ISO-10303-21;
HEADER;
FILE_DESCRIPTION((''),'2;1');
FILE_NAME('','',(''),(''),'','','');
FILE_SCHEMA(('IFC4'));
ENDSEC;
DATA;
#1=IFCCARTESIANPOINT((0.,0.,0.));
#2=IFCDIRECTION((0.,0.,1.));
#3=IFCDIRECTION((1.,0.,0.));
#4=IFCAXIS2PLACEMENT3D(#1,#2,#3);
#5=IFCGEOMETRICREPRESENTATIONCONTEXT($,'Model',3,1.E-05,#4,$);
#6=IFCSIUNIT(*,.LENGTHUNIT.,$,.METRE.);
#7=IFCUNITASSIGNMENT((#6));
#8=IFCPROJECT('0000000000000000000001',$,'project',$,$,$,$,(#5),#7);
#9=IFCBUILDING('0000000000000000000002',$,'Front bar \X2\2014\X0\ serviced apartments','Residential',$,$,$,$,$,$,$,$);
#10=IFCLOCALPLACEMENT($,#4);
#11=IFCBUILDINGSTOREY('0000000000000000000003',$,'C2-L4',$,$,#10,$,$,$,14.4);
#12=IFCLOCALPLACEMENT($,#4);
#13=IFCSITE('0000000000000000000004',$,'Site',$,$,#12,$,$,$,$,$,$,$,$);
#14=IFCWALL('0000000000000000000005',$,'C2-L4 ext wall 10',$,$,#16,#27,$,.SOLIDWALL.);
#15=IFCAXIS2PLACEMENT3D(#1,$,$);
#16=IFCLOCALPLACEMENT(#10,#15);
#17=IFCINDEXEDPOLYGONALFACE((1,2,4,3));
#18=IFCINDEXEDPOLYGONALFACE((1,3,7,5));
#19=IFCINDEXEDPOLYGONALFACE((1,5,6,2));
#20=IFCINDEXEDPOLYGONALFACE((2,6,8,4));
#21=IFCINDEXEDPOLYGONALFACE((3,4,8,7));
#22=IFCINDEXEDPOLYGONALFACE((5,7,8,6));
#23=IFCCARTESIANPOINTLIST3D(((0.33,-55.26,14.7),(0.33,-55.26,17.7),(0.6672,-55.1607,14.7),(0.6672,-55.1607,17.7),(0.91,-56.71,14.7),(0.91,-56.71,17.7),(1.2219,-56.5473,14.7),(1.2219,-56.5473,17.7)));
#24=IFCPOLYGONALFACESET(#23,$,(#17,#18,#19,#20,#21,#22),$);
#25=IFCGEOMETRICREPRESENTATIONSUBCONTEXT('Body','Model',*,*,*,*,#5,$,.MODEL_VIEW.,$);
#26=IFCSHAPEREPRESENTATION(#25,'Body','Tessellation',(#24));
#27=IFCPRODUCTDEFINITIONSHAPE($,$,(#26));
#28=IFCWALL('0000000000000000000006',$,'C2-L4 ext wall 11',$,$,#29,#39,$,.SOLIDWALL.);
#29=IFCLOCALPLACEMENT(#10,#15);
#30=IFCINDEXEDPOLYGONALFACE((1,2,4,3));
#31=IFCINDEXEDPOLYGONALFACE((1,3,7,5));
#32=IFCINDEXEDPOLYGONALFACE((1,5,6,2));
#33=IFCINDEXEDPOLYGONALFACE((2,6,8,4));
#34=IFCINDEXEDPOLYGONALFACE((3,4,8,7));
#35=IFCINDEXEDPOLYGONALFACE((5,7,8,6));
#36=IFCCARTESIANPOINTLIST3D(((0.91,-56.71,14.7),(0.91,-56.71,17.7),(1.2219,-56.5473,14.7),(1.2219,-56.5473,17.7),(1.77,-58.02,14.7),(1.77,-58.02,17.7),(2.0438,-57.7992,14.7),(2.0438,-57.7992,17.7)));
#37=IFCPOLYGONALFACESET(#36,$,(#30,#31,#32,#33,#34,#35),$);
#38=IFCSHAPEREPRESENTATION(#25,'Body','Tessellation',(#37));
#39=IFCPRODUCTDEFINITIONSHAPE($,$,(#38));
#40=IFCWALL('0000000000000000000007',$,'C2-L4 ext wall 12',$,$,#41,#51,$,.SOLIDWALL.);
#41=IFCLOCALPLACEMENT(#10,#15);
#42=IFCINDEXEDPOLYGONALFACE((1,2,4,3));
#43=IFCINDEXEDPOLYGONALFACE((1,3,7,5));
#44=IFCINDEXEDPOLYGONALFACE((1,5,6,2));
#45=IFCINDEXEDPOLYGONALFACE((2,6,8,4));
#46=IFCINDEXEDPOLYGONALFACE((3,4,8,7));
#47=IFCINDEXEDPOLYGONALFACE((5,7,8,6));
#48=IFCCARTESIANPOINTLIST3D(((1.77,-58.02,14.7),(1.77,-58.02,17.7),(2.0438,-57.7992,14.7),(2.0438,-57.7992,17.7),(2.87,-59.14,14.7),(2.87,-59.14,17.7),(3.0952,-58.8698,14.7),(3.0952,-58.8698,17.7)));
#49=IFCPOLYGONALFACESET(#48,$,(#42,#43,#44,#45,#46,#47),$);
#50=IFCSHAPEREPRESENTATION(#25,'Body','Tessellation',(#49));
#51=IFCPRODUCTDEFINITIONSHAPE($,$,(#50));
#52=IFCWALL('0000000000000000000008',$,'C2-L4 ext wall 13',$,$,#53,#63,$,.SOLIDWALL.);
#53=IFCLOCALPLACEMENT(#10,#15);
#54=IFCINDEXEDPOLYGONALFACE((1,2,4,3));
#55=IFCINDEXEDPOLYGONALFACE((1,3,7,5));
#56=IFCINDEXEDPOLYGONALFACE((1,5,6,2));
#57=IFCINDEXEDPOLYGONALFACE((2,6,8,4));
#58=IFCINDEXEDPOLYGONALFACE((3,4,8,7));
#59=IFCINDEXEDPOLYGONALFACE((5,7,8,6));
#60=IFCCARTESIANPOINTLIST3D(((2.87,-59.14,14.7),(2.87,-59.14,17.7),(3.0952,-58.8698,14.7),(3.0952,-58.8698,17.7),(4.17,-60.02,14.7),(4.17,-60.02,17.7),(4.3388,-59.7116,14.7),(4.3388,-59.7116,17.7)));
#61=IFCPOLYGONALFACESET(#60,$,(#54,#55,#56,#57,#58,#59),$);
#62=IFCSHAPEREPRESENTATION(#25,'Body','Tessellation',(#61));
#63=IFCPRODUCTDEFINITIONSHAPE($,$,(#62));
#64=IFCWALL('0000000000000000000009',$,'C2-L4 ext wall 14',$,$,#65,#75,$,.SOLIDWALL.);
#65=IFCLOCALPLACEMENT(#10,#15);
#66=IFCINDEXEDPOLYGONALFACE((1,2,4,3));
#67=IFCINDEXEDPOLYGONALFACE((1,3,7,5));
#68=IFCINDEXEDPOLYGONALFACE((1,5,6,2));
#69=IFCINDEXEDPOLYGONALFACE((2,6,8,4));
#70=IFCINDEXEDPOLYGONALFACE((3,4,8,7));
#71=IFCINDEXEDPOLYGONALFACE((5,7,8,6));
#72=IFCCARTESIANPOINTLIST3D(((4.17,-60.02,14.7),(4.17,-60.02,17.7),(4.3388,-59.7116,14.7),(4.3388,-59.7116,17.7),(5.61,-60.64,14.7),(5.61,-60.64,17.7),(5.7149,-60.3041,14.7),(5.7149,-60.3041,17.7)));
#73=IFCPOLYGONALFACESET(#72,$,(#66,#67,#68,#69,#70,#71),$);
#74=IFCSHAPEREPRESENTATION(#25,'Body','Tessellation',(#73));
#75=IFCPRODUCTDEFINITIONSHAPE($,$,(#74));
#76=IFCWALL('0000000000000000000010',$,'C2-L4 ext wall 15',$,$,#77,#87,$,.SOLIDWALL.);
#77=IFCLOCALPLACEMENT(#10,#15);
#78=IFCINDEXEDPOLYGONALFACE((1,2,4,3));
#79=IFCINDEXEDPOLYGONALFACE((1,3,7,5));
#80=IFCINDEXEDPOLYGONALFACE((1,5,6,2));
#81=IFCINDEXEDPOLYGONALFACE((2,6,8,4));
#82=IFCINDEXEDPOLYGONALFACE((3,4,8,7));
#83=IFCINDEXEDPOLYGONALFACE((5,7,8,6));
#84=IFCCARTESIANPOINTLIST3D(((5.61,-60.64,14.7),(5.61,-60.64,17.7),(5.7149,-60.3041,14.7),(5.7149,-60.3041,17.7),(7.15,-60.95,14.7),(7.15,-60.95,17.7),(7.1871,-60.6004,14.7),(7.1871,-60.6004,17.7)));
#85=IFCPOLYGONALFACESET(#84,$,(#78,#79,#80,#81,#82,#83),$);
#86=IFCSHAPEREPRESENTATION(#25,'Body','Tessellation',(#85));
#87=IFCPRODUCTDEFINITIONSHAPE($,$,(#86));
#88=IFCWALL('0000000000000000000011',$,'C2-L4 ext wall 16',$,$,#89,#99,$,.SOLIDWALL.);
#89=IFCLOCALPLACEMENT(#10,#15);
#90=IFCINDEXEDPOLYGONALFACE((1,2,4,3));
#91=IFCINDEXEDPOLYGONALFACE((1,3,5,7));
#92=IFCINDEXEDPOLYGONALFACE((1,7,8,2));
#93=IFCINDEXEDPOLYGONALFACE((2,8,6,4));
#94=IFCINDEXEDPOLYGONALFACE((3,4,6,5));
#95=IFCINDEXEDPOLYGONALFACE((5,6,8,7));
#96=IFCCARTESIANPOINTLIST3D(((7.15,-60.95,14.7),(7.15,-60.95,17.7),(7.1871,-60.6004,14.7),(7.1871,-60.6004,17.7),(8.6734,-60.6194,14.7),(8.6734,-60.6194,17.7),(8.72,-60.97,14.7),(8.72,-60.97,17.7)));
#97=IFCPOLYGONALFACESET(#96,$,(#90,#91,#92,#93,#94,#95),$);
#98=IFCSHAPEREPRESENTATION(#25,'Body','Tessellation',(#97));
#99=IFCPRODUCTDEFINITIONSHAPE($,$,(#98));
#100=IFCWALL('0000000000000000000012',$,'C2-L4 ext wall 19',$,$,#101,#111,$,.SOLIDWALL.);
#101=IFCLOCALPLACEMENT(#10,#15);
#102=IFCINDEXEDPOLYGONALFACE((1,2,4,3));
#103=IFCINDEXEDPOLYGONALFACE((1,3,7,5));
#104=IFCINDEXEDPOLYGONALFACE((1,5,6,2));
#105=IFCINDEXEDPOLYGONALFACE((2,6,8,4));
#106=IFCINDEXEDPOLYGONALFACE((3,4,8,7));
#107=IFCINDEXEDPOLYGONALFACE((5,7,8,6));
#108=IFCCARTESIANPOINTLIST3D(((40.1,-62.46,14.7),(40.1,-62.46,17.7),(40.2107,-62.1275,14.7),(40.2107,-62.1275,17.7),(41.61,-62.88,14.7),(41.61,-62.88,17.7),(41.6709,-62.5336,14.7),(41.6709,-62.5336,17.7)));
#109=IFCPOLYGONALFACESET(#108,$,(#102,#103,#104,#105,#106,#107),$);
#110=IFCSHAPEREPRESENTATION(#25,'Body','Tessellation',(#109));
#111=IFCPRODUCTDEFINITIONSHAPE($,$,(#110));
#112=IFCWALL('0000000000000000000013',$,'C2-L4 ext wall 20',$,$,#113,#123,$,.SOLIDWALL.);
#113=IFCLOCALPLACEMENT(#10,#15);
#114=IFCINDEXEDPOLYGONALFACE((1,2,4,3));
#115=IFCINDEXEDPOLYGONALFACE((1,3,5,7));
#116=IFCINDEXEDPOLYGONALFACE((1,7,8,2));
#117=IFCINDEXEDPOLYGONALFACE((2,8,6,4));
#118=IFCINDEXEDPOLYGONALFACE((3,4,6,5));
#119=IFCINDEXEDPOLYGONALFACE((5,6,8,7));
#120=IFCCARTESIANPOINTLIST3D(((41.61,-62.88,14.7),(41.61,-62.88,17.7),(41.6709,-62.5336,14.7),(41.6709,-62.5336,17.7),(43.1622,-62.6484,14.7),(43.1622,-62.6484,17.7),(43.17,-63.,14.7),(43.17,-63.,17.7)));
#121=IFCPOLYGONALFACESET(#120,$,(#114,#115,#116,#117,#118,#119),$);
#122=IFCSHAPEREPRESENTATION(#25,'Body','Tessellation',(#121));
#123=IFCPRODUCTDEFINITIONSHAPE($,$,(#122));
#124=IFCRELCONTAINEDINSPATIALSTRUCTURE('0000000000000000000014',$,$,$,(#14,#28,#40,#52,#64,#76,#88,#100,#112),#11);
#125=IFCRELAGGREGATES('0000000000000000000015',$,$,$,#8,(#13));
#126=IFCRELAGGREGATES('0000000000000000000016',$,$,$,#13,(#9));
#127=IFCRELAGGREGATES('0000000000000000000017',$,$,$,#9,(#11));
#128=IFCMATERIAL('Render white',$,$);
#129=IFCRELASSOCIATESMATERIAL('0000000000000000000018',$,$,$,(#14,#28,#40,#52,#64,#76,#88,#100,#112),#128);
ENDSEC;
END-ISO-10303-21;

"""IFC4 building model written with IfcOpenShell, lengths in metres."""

from ifc_helpers import new_model, si_unit, frame, origin_with_axes, place, context, subcontext, project, spatial, polyline, outline, extrude, material, element, save


model = new_model("IFC4")

# Units and contexts
model_context = context("Model", 3, precision=1e-05, world=origin_with_axes())
body_context = subcontext(model_context, "Body", "Model", "MODEL_VIEW")
ifc_project = project(units=[si_unit("LENGTHUNIT", "METRE")], contexts=[model_context])

# Site, building, storey
site_placement = place(None, origin_with_axes())
site = spatial("IfcSite", under=ifc_project, at=site_placement, Name="Site")
building = spatial("IfcBuilding", under=site, Name="Front bar — serviced apartments", Description="Residential")
storey_placement = place(None, origin_with_axes())
storey = spatial("IfcBuildingStorey", under=building, at=storey_placement, Name="C2-L4", Elevation=14.4)

# Walls
ifc_material_1 = material(Name="Render white")
wall_1_placement = place(storey_placement, origin_with_axes())
element("IfcWall", 1, at=wall_1_placement, inside=storey, material=ifc_material_1, Name="C2-L4 ext wall 10", PredefinedType="SOLIDWALL", context=body_context, shape_type="SweptSolid", body=[
    extrude(outline(polyline([(0.33, -55.26), (0.91, -56.71), (1.2219, -56.5473), (0.6672, -55.1607), (0.33, -55.26)])), frame((0.0, 0.0, 14.7), z_axis=(0.0, 0.0, 1.0), x_axis=(1.0, 0.0, 0.0)), (0.0, 0.0, 1.0), 3.0),
])
wall_2_placement = place(storey_placement, origin_with_axes())
element("IfcWall", 2, at=wall_2_placement, inside=storey, material=ifc_material_1, Name="C2-L4 ext wall 11", PredefinedType="SOLIDWALL", context=body_context, shape_type="SweptSolid", body=[
    extrude(outline(polyline([(0.91, -56.71), (1.77, -58.02), (2.0438, -57.7992), (1.2219, -56.5473), (0.91, -56.71)])), frame((0.0, 0.0, 14.7), z_axis=(0.0, 0.0, 1.0), x_axis=(1.0, 0.0, 0.0)), (0.0, 0.0, 1.0), 3.0),
])
wall_3_placement = place(storey_placement, origin_with_axes())
element("IfcWall", 3, at=wall_3_placement, inside=storey, material=ifc_material_1, Name="C2-L4 ext wall 12", PredefinedType="SOLIDWALL", context=body_context, shape_type="SweptSolid", body=[
    extrude(outline(polyline([(1.77, -58.02), (2.87, -59.14), (3.0952, -58.8698), (2.0438, -57.7992), (1.77, -58.02)])), frame((0.0, 0.0, 14.7), z_axis=(0.0, 0.0, 1.0), x_axis=(1.0, 0.0, 0.0)), (0.0, 0.0, 1.0), 3.0),
])
wall_4_placement = place(storey_placement, origin_with_axes())
element("IfcWall", 4, at=wall_4_placement, inside=storey, material=ifc_material_1, Name="C2-L4 ext wall 13", PredefinedType="SOLIDWALL", context=body_context, shape_type="SweptSolid", body=[
    extrude(outline(polyline([(2.87, -59.14), (4.17, -60.02), (4.3388, -59.7116), (3.0952, -58.8698), (2.87, -59.14)])), frame((0.0, 0.0, 14.7), z_axis=(0.0, 0.0, 1.0), x_axis=(1.0, 0.0, 0.0)), (0.0, 0.0, 1.0), 3.0),
])
wall_5_placement = place(storey_placement, origin_with_axes())
element("IfcWall", 5, at=wall_5_placement, inside=storey, material=ifc_material_1, Name="C2-L4 ext wall 14", PredefinedType="SOLIDWALL", context=body_context, shape_type="SweptSolid", body=[
    extrude(outline(polyline([(4.17, -60.02), (5.61, -60.64), (5.7149, -60.3041), (4.3388, -59.7116), (4.17, -60.02)])), frame((0.0, 0.0, 14.7), z_axis=(0.0, 0.0, 1.0), x_axis=(1.0, 0.0, 0.0)), (0.0, 0.0, 1.0), 3.0),
])
wall_6_placement = place(storey_placement, origin_with_axes())
element("IfcWall", 6, at=wall_6_placement, inside=storey, material=ifc_material_1, Name="C2-L4 ext wall 15", PredefinedType="SOLIDWALL", context=body_context, shape_type="SweptSolid", body=[
    extrude(outline(polyline([(5.61, -60.64), (7.15, -60.95), (7.1871, -60.6004), (5.7149, -60.3041), (5.61, -60.64)])), frame((0.0, 0.0, 14.7), z_axis=(0.0, 0.0, 1.0), x_axis=(1.0, 0.0, 0.0)), (0.0, 0.0, 1.0), 3.0),
])
wall_7_placement = place(storey_placement, origin_with_axes())
element("IfcWall", 7, at=wall_7_placement, inside=storey, material=ifc_material_1, Name="C2-L4 ext wall 16", PredefinedType="SOLIDWALL", context=body_context, shape_type="SweptSolid", body=[
    extrude(outline(polyline([(7.15, -60.95), (8.72, -60.97), (8.6734, -60.6194), (7.1871, -60.6004), (7.15, -60.95)])), frame((0.0, 0.0, 14.7), z_axis=(0.0, 0.0, 1.0), x_axis=(1.0, 0.0, 0.0)), (0.0, 0.0, 1.0), 3.0),
])

# Walls
wall_8_placement = place(storey_placement, origin_with_axes())
element("IfcWall", 8, at=wall_8_placement, inside=storey, material=ifc_material_1, Name="C2-L4 ext wall 19", PredefinedType="SOLIDWALL", context=body_context, shape_type="SweptSolid", body=[
    extrude(outline(polyline([(40.1, -62.46), (41.61, -62.88), (41.6709, -62.5336), (40.2107, -62.1275), (40.1, -62.46)])), frame((0.0, 0.0, 14.7), z_axis=(0.0, 0.0, 1.0), x_axis=(1.0, 0.0, 0.0)), (0.0, 0.0, 1.0), 3.0),
])
wall_9_placement = place(storey_placement, origin_with_axes())
element("IfcWall", 9, at=wall_9_placement, inside=storey, material=ifc_material_1, Name="C2-L4 ext wall 20", PredefinedType="SOLIDWALL", context=body_context, shape_type="SweptSolid", body=[
    extrude(outline(polyline([(41.61, -62.88), (43.17, -63.0), (43.1622, -62.6484), (41.6709, -62.5336), (41.61, -62.88)])), frame((0.0, 0.0, 14.7), z_axis=(0.0, 0.0, 1.0), x_axis=(1.0, 0.0, 0.0)), (0.0, 0.0, 1.0), 3.0),
])

save(model, "model.ifc")
